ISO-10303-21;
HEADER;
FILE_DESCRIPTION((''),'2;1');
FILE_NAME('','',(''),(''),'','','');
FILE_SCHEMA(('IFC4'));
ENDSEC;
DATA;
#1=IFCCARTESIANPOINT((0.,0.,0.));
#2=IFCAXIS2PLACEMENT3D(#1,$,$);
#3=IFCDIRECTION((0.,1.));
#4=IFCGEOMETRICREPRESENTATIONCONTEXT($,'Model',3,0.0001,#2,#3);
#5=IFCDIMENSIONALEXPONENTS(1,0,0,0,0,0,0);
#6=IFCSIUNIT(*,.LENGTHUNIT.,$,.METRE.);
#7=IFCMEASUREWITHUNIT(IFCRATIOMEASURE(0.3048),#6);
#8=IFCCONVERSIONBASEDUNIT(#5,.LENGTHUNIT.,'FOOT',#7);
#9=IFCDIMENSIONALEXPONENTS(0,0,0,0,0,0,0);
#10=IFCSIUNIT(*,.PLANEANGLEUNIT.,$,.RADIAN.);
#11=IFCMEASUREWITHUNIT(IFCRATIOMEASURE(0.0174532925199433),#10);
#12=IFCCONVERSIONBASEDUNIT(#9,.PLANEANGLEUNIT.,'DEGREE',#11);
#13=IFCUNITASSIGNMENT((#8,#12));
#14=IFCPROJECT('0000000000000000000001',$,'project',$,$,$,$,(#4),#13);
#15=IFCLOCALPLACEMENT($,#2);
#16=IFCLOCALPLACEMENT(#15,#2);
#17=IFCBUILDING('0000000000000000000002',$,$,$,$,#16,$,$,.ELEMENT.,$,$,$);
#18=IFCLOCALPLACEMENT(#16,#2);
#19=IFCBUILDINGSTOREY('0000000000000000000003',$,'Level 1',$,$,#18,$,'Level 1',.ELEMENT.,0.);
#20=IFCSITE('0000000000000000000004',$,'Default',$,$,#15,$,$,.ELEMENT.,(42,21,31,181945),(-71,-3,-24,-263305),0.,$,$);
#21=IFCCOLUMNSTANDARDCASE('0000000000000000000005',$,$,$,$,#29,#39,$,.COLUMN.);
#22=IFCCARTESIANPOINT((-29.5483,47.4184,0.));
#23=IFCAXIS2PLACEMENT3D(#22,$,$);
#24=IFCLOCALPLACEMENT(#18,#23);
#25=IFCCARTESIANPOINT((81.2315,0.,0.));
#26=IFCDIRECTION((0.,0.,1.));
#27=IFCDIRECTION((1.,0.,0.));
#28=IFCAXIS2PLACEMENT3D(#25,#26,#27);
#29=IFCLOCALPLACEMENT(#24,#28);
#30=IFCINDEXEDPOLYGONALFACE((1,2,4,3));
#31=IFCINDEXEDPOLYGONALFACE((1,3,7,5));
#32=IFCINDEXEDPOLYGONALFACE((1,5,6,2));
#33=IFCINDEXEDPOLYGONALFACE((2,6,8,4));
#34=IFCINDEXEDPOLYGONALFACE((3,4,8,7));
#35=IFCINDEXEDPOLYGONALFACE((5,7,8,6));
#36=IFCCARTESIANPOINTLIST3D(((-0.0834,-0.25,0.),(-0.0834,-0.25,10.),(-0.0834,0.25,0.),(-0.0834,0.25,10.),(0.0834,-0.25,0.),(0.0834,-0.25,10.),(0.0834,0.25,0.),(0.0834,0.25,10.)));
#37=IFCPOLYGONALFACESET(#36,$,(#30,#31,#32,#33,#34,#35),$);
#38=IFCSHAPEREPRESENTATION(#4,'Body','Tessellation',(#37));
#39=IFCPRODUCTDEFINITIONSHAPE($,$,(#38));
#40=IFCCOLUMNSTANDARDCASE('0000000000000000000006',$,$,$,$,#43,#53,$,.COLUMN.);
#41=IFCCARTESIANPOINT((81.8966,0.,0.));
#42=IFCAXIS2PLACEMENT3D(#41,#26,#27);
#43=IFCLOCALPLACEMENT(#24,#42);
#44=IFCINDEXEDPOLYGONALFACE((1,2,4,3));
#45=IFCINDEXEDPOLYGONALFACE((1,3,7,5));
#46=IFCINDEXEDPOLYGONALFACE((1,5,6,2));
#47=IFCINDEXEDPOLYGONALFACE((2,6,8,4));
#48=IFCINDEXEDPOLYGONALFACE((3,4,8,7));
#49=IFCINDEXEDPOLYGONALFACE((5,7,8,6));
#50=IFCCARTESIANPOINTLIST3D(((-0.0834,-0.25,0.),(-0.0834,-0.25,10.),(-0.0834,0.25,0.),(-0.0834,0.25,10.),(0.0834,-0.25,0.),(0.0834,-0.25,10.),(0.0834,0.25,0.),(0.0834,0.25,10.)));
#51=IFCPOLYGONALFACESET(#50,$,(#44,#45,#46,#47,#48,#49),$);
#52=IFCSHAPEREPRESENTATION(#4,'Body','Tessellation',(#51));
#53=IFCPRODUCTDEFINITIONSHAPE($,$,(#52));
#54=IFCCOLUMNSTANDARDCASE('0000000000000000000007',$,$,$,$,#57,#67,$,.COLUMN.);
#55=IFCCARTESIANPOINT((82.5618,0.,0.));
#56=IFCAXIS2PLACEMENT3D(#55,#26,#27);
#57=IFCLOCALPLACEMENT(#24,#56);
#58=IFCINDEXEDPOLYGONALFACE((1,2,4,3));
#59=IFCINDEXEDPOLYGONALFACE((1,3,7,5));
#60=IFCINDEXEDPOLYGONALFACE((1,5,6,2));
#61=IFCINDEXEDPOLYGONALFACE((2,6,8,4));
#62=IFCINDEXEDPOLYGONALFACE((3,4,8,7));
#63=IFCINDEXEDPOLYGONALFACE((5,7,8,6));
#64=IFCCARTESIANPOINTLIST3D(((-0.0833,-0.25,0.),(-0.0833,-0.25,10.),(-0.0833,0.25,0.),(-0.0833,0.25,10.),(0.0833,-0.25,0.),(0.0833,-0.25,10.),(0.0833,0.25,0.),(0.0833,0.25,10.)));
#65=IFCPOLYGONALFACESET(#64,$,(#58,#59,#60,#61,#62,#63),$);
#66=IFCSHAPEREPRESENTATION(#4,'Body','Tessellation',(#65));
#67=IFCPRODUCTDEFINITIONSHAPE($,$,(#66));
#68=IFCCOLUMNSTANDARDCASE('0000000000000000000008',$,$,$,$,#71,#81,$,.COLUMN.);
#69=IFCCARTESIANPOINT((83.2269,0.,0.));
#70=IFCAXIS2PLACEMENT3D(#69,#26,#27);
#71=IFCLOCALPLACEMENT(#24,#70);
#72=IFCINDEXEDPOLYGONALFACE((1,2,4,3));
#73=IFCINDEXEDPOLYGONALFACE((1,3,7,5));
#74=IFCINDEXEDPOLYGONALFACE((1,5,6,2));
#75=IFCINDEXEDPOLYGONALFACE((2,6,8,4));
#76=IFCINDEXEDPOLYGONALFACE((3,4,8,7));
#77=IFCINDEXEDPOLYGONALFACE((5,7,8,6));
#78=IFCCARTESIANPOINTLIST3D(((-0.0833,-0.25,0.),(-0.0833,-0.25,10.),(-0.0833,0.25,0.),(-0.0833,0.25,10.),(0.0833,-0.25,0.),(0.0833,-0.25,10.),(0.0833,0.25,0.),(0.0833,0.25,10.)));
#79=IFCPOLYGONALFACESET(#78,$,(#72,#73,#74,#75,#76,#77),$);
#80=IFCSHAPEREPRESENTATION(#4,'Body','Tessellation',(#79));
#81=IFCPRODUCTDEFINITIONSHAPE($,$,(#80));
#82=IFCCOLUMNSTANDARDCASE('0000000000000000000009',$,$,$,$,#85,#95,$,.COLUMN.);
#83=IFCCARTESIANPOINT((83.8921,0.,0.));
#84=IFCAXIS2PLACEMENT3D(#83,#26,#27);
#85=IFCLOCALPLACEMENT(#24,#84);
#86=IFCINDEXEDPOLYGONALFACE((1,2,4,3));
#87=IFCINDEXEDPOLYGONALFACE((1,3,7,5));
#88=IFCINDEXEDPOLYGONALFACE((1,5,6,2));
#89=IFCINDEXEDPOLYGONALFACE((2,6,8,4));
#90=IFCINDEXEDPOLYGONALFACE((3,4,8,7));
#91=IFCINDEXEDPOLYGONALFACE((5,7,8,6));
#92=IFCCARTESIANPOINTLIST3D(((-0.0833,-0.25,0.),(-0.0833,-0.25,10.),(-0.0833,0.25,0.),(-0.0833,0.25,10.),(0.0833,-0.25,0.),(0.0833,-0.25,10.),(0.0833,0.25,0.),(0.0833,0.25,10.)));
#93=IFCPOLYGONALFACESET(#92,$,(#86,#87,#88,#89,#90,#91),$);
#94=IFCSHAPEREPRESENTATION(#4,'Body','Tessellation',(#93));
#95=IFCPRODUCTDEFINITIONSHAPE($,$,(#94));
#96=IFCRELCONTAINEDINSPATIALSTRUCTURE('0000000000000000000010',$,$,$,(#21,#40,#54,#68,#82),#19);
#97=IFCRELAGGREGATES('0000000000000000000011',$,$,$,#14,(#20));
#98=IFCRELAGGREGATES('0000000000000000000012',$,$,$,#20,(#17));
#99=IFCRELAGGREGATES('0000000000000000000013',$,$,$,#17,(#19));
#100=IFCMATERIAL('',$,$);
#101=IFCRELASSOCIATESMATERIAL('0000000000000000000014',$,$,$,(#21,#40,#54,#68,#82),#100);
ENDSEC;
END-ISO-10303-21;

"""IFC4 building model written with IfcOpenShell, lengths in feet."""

from ifc_helpers import new_model, entity, si_unit, converted_unit, direction, frame, origin, place, context, project, spatial, rectangle, extrude, material, element, save


model = new_model("IFC4")

# Units and contexts
model_context = context("Model", 3, precision=0.0001, world=origin(), true_north=direction((0.0, 1.0)))
ifc_project = project(units=[converted_unit("LENGTHUNIT", "FOOT", entity("IfcRatioMeasure", 0.3048), si_unit("LENGTHUNIT", "METRE"), dimensions=[1, 0, 0, 0, 0, 0, 0]), converted_unit("PLANEANGLEUNIT", "DEGREE", entity("IfcRatioMeasure", 0.0174532925199433), si_unit("PLANEANGLEUNIT", "RADIAN"), dimensions=[0, 0, 0, 0, 0, 0, 0])], contexts=[model_context])

# Site, building, storey
site_placement = place(None, origin())
site = spatial("IfcSite", under=ifc_project, at=site_placement, Name="Default", CompositionType="ELEMENT", RefLatitude=(42, 21, 31, 181945), RefLongitude=(-71, -3, -24, -263305), RefElevation=0.0)
building_placement = place(site_placement, origin())
building = spatial("IfcBuilding", under=site, at=building_placement, CompositionType="ELEMENT")
storey_placement = place(building_placement, origin())
storey = spatial("IfcBuildingStorey", under=building, at=storey_placement, Name="Level 1", LongName="Level 1", CompositionType="ELEMENT", Elevation=0.0)

# Columns
ifc_material_1 = material(Name="")
placement = place(storey_placement, frame((-29.5483, 47.4184, 0.0)))
for number, where, z_axis, x_axis in (
    (1, (81.2315, 0.0, 0.0), (0.0, 0.0, 1.0), (1.0, 0.0, 0.0)),
    (2, (81.8966, 0.0, 0.0), (0.0, 0.0, 1.0), (1.0, 0.0, 0.0)),
    (3, (82.5618, 0.0, 0.0), (0.0, 0.0, 1.0), (1.0, 0.0, 0.0)),
    (4, (83.2269, 0.0, 0.0), (0.0, 0.0, 1.0), (1.0, 0.0, 0.0)),
    (5, (83.8921, 0.0, 0.0), (0.0, 0.0, 1.0), (1.0, 0.0, 0.0)),
):
    element("IfcColumnStandardCase", number, at=place(placement, frame(where, z_axis=z_axis, x_axis=x_axis)), inside=storey, material=ifc_material_1, PredefinedType="COLUMN", context=model_context, shape_type="SweptSolid", body=[
        extrude(rectangle(XDim=0.1667, YDim=0.5), origin(), (0.0, 0.0, 1.0), 10.0),
    ])

save(model, "model.ifc")
